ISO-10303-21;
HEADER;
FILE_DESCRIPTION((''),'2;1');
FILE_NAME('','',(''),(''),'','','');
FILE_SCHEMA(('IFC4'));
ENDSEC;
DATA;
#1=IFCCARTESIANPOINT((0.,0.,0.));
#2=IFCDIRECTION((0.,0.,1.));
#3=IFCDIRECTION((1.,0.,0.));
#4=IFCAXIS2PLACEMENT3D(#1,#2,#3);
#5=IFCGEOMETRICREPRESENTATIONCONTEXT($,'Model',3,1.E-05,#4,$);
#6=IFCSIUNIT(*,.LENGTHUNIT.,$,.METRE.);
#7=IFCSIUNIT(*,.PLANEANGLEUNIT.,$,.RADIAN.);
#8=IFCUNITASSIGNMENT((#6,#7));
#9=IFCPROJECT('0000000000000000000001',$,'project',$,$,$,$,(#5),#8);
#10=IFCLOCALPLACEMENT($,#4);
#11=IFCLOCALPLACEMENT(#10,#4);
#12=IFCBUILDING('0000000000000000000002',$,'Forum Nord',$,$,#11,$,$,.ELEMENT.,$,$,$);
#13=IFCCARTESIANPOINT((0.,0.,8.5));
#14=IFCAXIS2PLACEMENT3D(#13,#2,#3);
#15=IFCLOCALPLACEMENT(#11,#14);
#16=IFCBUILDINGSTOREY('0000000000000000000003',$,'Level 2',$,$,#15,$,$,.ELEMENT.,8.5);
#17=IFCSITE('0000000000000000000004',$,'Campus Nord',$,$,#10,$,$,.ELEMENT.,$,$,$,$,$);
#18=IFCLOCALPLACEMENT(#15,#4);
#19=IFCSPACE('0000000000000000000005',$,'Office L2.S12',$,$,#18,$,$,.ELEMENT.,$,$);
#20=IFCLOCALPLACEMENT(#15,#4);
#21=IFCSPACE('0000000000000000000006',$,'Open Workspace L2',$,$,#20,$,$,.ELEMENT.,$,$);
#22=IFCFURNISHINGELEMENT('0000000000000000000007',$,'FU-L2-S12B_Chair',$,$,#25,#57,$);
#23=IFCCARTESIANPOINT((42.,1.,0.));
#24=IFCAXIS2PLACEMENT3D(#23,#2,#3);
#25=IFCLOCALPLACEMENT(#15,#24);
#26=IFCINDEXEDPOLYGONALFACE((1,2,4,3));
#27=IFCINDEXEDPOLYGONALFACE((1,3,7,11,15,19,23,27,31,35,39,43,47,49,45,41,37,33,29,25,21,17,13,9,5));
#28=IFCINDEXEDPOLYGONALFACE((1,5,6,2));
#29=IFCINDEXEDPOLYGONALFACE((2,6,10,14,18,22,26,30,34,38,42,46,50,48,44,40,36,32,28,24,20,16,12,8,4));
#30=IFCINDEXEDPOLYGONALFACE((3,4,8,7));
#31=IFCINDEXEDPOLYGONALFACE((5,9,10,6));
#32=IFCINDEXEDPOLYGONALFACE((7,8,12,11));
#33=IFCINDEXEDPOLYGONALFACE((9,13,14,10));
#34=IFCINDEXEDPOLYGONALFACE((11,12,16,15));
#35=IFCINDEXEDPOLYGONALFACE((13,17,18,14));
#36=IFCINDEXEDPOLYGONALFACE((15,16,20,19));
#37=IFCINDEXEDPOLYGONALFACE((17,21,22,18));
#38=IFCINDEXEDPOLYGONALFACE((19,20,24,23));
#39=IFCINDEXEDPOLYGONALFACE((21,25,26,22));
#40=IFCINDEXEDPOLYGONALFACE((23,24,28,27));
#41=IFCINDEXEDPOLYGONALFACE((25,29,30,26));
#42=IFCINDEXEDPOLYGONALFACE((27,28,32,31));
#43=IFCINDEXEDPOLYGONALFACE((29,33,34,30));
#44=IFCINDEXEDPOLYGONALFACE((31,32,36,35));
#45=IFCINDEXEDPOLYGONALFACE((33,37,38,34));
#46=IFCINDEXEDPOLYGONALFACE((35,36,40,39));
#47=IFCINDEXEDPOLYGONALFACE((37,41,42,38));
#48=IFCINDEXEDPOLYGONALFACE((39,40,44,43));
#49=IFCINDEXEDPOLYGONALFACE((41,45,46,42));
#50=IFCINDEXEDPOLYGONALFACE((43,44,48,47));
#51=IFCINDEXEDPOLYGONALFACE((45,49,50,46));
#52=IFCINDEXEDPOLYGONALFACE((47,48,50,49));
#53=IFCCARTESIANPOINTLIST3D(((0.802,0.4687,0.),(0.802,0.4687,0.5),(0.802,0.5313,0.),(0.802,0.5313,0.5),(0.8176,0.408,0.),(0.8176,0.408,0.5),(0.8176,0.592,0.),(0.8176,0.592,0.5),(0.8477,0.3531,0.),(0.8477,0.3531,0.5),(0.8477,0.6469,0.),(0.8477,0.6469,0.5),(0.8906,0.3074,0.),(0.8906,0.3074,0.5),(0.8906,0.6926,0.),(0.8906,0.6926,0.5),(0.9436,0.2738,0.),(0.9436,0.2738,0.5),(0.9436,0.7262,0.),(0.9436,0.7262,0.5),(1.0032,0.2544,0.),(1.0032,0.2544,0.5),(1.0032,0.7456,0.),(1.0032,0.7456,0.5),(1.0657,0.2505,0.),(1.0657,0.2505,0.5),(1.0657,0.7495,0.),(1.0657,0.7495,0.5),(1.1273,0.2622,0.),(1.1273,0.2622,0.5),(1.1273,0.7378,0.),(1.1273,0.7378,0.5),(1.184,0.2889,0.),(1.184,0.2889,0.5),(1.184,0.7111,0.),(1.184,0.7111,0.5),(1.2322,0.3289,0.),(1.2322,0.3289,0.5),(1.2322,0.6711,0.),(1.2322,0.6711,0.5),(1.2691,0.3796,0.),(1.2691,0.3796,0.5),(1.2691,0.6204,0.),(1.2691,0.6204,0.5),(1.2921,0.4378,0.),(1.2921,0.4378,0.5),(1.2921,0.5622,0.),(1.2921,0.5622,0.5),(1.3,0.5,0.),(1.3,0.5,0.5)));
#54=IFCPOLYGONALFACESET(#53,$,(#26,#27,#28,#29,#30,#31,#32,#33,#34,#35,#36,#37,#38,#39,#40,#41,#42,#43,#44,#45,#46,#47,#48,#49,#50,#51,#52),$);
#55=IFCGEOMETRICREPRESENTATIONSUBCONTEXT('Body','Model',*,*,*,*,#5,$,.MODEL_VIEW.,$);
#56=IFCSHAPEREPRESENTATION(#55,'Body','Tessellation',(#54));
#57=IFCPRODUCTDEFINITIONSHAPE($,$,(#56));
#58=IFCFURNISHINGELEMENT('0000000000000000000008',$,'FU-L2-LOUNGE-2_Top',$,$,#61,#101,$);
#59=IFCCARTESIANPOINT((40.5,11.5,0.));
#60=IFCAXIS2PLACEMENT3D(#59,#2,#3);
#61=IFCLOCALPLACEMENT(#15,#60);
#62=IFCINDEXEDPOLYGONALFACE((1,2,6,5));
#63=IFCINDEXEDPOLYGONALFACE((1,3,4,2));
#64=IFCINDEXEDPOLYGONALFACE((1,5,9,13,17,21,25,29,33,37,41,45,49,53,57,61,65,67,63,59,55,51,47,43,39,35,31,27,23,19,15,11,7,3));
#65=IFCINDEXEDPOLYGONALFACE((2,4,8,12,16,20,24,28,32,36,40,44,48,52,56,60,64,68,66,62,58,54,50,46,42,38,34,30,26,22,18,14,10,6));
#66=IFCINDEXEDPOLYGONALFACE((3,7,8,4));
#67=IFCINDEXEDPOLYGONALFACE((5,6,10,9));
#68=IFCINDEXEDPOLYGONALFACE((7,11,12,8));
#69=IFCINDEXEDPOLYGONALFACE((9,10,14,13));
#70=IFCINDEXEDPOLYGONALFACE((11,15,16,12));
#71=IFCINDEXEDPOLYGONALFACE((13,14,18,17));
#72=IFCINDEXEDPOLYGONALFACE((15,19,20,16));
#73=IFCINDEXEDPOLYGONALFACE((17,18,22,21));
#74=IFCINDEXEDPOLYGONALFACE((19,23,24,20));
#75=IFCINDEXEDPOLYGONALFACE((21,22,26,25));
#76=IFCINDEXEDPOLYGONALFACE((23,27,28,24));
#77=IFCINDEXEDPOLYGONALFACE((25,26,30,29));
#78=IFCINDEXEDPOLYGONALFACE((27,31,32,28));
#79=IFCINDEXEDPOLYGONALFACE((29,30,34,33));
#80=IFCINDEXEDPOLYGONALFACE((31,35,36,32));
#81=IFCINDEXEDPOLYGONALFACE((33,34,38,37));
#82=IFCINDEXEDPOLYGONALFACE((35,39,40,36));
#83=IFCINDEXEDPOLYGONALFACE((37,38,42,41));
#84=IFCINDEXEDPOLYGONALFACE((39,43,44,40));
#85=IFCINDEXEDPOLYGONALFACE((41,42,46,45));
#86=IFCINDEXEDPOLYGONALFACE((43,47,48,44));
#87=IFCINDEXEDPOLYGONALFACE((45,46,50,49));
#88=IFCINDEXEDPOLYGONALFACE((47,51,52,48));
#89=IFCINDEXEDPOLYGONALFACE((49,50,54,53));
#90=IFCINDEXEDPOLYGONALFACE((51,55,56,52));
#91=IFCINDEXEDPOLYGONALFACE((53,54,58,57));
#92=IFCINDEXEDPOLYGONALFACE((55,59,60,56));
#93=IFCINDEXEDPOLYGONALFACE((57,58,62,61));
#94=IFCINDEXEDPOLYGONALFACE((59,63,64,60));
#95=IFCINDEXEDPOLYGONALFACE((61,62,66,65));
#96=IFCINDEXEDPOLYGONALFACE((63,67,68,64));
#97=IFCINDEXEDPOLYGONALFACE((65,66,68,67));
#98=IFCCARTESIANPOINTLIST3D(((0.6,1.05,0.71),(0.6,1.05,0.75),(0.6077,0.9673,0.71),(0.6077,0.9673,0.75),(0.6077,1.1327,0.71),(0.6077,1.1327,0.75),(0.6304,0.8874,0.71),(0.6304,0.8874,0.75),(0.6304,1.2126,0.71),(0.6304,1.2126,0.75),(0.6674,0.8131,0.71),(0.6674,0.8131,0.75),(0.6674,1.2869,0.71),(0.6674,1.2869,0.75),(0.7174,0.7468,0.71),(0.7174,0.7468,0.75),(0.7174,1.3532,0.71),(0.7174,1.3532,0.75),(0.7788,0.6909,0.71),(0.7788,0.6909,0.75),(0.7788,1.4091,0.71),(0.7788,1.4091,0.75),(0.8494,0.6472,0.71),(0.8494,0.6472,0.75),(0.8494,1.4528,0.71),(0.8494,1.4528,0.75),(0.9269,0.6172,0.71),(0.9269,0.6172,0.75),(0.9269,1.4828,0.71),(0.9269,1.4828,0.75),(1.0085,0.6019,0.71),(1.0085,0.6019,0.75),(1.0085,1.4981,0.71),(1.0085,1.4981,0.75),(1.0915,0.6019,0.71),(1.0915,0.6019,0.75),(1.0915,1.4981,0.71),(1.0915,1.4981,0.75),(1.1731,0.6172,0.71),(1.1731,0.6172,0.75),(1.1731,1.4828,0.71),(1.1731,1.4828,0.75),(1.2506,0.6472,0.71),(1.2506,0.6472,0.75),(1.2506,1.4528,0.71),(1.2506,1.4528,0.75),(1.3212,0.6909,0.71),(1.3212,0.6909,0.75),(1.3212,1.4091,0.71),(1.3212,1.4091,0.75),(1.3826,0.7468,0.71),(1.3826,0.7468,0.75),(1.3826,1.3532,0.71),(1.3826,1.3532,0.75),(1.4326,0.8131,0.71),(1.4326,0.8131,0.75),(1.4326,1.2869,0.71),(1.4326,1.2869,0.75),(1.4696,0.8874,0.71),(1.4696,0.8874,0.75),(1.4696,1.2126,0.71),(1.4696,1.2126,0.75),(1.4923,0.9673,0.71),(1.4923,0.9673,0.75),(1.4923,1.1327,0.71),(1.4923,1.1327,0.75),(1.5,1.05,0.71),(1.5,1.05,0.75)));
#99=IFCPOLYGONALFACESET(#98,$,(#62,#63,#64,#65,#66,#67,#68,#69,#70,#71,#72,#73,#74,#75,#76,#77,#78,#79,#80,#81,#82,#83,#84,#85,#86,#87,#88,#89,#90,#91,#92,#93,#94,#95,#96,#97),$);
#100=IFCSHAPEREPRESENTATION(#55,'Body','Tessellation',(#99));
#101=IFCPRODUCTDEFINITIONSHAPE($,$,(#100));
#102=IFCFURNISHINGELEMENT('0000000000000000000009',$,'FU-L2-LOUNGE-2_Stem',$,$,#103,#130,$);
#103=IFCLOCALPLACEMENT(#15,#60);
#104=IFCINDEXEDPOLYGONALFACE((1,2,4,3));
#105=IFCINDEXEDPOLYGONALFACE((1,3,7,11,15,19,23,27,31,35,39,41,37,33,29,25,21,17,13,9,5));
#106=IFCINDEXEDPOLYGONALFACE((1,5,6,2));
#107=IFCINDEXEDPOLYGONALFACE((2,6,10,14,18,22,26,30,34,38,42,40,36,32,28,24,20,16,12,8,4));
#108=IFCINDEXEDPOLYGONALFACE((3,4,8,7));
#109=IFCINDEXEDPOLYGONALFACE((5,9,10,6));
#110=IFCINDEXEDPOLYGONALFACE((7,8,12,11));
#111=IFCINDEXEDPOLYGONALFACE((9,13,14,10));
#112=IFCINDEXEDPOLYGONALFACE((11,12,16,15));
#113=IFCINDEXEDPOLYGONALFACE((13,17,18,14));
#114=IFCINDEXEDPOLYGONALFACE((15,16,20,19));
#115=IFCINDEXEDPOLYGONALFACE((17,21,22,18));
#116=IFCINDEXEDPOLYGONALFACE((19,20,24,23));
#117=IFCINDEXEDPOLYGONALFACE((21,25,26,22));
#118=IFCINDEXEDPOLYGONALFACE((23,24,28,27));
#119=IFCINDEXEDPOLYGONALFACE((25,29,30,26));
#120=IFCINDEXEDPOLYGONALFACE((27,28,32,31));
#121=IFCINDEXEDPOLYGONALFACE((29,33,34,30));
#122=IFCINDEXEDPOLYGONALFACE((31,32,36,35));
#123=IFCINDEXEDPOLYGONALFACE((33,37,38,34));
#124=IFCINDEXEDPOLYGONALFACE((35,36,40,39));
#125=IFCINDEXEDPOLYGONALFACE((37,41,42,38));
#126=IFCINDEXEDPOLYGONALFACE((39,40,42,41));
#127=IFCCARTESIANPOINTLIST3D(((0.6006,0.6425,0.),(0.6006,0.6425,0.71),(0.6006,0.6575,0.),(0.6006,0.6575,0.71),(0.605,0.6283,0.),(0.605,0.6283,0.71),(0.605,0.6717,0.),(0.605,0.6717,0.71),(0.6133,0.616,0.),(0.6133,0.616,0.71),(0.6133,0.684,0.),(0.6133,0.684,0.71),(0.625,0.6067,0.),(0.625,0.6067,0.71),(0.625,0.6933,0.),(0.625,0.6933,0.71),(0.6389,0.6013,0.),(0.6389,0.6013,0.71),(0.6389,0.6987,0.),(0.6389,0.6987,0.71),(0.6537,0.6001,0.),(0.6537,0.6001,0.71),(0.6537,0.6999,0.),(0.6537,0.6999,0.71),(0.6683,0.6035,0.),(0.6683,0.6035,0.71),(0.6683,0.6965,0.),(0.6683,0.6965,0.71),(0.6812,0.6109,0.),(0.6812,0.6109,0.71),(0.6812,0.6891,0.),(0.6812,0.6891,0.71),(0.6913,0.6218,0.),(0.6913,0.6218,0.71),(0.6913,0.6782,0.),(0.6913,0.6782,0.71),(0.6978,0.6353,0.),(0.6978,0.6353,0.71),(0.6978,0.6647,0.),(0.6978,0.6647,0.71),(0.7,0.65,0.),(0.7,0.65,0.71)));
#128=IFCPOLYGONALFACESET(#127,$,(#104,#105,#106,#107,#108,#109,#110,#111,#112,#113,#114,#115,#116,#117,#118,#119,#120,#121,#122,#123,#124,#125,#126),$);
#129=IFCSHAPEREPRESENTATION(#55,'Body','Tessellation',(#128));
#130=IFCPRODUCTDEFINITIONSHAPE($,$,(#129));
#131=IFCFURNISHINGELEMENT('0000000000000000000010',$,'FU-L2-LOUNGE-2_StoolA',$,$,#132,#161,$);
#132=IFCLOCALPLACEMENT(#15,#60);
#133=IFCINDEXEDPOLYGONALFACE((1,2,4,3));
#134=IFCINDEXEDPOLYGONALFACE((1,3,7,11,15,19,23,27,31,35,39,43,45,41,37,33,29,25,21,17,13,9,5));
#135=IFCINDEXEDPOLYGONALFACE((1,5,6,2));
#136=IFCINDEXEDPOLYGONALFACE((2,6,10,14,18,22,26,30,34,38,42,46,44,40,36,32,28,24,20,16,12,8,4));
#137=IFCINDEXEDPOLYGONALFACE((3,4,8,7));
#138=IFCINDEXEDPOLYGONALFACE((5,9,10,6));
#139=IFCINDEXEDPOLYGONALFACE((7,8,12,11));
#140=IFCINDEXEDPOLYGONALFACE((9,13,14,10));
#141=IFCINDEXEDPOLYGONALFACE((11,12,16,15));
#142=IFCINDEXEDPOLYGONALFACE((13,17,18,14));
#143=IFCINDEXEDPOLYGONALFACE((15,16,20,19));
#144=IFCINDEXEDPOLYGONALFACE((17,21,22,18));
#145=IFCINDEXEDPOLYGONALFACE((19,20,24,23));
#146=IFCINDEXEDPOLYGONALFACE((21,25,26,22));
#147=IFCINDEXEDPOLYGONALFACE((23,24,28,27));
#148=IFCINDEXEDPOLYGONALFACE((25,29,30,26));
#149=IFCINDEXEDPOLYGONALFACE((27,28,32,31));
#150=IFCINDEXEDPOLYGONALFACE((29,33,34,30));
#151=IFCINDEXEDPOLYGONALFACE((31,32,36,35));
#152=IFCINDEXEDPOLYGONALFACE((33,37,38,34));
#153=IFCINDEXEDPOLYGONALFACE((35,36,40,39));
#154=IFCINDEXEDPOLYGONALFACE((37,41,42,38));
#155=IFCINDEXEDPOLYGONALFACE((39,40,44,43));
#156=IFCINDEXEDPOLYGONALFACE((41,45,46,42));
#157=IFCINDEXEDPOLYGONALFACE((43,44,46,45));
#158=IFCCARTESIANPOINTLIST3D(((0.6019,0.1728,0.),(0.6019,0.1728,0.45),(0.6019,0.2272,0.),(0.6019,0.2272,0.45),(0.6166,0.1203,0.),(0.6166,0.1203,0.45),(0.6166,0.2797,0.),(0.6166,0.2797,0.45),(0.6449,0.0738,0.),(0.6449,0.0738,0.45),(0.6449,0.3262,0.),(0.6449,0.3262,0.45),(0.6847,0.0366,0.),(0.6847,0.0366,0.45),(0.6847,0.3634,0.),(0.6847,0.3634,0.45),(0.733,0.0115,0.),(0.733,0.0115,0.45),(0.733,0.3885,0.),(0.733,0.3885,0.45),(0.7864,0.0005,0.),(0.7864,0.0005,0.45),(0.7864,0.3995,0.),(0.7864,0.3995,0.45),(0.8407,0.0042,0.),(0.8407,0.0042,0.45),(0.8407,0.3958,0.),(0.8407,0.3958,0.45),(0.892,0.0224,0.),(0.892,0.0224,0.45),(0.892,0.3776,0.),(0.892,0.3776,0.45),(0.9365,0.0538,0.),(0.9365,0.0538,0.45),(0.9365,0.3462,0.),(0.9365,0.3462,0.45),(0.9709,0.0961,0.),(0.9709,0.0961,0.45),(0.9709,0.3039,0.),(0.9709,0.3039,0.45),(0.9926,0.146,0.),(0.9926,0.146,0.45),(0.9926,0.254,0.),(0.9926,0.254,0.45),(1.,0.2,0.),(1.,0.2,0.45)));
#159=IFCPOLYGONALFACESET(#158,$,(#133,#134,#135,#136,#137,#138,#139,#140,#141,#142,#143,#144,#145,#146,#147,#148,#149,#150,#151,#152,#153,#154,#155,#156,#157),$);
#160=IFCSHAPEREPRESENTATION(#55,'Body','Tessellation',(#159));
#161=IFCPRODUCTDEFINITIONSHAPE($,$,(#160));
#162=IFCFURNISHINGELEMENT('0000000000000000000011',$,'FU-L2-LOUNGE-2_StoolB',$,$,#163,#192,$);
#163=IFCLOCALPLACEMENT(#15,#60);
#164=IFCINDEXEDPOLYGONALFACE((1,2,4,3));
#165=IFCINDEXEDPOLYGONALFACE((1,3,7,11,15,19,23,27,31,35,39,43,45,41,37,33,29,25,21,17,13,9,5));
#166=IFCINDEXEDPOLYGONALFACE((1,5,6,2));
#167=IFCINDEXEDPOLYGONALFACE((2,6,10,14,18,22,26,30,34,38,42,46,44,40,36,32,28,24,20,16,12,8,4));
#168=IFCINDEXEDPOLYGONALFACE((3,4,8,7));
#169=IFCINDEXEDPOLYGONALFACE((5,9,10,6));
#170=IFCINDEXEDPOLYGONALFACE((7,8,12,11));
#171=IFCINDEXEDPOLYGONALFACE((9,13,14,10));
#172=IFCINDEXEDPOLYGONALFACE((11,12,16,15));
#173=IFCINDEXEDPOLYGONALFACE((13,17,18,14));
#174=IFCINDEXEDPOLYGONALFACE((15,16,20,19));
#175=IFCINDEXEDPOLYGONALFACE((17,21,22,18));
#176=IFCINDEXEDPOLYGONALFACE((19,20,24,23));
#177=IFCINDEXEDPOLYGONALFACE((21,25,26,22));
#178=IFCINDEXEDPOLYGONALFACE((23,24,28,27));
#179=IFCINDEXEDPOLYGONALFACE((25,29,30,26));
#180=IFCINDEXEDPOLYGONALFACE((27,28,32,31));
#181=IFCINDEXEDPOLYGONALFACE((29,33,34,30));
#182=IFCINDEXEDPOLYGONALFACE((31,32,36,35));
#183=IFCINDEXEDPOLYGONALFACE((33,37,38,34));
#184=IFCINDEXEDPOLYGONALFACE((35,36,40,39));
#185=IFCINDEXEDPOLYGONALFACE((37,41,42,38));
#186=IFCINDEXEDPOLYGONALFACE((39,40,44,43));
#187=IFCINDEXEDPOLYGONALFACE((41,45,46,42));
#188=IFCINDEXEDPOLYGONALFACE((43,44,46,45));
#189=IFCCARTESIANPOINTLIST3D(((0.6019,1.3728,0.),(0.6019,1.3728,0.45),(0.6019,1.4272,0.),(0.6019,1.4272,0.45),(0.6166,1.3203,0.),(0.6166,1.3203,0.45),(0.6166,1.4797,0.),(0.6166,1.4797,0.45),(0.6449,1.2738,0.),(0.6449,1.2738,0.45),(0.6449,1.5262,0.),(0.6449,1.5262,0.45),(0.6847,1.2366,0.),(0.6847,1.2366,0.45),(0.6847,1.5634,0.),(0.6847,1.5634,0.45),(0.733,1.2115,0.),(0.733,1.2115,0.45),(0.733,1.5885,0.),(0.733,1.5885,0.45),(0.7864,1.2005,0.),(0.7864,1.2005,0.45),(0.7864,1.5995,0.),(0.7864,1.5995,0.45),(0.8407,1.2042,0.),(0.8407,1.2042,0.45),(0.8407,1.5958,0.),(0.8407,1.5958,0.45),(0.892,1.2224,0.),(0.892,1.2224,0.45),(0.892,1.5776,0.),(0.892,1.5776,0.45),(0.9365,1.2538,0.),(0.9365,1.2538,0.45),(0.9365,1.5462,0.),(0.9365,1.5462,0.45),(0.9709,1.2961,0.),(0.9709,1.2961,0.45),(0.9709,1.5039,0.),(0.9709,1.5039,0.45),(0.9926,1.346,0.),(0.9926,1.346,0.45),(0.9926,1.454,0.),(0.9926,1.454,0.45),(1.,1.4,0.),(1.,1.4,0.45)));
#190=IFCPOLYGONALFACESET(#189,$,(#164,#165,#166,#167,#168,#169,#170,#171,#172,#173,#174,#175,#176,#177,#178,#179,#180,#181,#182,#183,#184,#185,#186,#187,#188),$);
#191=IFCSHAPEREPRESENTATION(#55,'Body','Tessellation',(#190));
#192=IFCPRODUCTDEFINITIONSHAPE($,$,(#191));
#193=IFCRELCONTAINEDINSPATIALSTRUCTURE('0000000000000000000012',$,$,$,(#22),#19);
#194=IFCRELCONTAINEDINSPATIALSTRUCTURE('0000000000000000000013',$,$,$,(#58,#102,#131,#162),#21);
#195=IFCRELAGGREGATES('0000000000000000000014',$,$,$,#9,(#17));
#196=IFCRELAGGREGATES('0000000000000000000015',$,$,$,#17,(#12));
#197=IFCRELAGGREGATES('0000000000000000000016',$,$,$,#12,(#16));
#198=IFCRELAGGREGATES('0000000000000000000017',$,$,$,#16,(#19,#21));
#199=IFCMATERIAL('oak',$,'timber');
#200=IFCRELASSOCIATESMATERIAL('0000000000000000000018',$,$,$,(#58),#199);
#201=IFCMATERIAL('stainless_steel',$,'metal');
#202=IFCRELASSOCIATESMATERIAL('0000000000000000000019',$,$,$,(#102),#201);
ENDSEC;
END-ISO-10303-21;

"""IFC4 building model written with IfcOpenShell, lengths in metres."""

from ifc_helpers import new_model, si_unit, frame, frame_2d, origin_with_axes, place, context, subcontext, project, spatial, circle, extrude, material, element, save


model = new_model("IFC4")

# Units and contexts
model_context = context("Model", 3, precision=1e-05, world=origin_with_axes())
body_context = subcontext(model_context, "Body", "Model", "MODEL_VIEW")
ifc_project = project(units=[si_unit("LENGTHUNIT", "METRE"), si_unit("PLANEANGLEUNIT", "RADIAN")], contexts=[model_context])

# Site, building, storey
site_placement = place(None, origin_with_axes())
site = spatial("IfcSite", under=ifc_project, at=site_placement, Name="Campus Nord", CompositionType="ELEMENT")
building_placement = place(site_placement, origin_with_axes())
building = spatial("IfcBuilding", under=site, at=building_placement, Name="Forum Nord", CompositionType="ELEMENT")
storey_placement = place(building_placement, frame((0.0, 0.0, 8.5), z_axis=(0.0, 0.0, 1.0), x_axis=(1.0, 0.0, 0.0)))
storey = spatial("IfcBuildingStorey", under=building, at=storey_placement, Name="Level 2", CompositionType="ELEMENT", Elevation=8.5)

# Shared definitions
space_1_placement = place(storey_placement, origin_with_axes())
space_1 = spatial("IfcSpace", under=storey, at=space_1_placement, Name="Office L2.S12", CompositionType="ELEMENT")

# Furnishing element
furnishing_1_placement = place(storey_placement, frame((42.0, 1.0, 0.0), z_axis=(0.0, 0.0, 1.0), x_axis=(1.0, 0.0, 0.0)))
element("IfcFurnishingElement", 1, at=furnishing_1_placement, inside=space_1, Name="FU-L2-S12B_Chair", context=body_context, shape_type="SweptSolid", body=[
    extrude(circle(Radius=0.25, at=frame_2d((1.05, 0.5), x_axis=(1.0, 0.0))), origin_with_axes(), (0.0, 0.0, 1.0), 0.5),
])

# Shared definitions
space_2_placement = place(storey_placement, origin_with_axes())
space_2 = spatial("IfcSpace", under=storey, at=space_2_placement, Name="Open Workspace L2", CompositionType="ELEMENT")

# Furnishing elements
ifc_material_1 = material(Name="oak", Category="timber")
furnishing_2_placement = place(storey_placement, frame((40.5, 11.5, 0.0), z_axis=(0.0, 0.0, 1.0), x_axis=(1.0, 0.0, 0.0)))
element("IfcFurnishingElement", 2, at=furnishing_2_placement, inside=space_2, material=ifc_material_1, Name="FU-L2-LOUNGE-2_Top", context=body_context, shape_type="SweptSolid", body=[
    extrude(circle(Radius=0.45, at=frame_2d((1.05, 1.05), x_axis=(1.0, 0.0))), frame((0.0, 0.0, 0.71), z_axis=(0.0, 0.0, 1.0), x_axis=(1.0, 0.0, 0.0)), (0.0, 0.0, 1.0), 0.04),
])
ifc_material_2 = material(Name="stainless_steel", Category="metal")
furnishing_3_placement = place(storey_placement, frame((40.5, 11.5, 0.0), z_axis=(0.0, 0.0, 1.0), x_axis=(1.0, 0.0, 0.0)))
element("IfcFurnishingElement", 3, at=furnishing_3_placement, inside=space_2, material=ifc_material_2, Name="FU-L2-LOUNGE-2_Stem", context=body_context, shape_type="SweptSolid", body=[
    extrude(circle(Radius=0.05, at=frame_2d((0.65, 0.65), x_axis=(1.0, 0.0))), origin_with_axes(), (0.0, 0.0, 1.0), 0.71),
])
furnishing_4_placement = place(storey_placement, frame((40.5, 11.5, 0.0), z_axis=(0.0, 0.0, 1.0), x_axis=(1.0, 0.0, 0.0)))
element("IfcFurnishingElement", 4, at=furnishing_4_placement, inside=space_2, Name="FU-L2-LOUNGE-2_StoolA", context=body_context, shape_type="SweptSolid", body=[
    extrude(circle(Radius=0.2, at=frame_2d((0.8, 0.2), x_axis=(1.0, 0.0))), origin_with_axes(), (0.0, 0.0, 1.0), 0.45),
])
furnishing_5_placement = place(storey_placement, frame((40.5, 11.5, 0.0), z_axis=(0.0, 0.0, 1.0), x_axis=(1.0, 0.0, 0.0)))
element("IfcFurnishingElement", 5, at=furnishing_5_placement, inside=space_2, Name="FU-L2-LOUNGE-2_StoolB", context=body_context, shape_type="SweptSolid", body=[
    extrude(circle(Radius=0.2, at=frame_2d((0.8, 1.4), x_axis=(1.0, 0.0))), origin_with_axes(), (0.0, 0.0, 1.0), 0.45),
])

save(model, "model.ifc")
